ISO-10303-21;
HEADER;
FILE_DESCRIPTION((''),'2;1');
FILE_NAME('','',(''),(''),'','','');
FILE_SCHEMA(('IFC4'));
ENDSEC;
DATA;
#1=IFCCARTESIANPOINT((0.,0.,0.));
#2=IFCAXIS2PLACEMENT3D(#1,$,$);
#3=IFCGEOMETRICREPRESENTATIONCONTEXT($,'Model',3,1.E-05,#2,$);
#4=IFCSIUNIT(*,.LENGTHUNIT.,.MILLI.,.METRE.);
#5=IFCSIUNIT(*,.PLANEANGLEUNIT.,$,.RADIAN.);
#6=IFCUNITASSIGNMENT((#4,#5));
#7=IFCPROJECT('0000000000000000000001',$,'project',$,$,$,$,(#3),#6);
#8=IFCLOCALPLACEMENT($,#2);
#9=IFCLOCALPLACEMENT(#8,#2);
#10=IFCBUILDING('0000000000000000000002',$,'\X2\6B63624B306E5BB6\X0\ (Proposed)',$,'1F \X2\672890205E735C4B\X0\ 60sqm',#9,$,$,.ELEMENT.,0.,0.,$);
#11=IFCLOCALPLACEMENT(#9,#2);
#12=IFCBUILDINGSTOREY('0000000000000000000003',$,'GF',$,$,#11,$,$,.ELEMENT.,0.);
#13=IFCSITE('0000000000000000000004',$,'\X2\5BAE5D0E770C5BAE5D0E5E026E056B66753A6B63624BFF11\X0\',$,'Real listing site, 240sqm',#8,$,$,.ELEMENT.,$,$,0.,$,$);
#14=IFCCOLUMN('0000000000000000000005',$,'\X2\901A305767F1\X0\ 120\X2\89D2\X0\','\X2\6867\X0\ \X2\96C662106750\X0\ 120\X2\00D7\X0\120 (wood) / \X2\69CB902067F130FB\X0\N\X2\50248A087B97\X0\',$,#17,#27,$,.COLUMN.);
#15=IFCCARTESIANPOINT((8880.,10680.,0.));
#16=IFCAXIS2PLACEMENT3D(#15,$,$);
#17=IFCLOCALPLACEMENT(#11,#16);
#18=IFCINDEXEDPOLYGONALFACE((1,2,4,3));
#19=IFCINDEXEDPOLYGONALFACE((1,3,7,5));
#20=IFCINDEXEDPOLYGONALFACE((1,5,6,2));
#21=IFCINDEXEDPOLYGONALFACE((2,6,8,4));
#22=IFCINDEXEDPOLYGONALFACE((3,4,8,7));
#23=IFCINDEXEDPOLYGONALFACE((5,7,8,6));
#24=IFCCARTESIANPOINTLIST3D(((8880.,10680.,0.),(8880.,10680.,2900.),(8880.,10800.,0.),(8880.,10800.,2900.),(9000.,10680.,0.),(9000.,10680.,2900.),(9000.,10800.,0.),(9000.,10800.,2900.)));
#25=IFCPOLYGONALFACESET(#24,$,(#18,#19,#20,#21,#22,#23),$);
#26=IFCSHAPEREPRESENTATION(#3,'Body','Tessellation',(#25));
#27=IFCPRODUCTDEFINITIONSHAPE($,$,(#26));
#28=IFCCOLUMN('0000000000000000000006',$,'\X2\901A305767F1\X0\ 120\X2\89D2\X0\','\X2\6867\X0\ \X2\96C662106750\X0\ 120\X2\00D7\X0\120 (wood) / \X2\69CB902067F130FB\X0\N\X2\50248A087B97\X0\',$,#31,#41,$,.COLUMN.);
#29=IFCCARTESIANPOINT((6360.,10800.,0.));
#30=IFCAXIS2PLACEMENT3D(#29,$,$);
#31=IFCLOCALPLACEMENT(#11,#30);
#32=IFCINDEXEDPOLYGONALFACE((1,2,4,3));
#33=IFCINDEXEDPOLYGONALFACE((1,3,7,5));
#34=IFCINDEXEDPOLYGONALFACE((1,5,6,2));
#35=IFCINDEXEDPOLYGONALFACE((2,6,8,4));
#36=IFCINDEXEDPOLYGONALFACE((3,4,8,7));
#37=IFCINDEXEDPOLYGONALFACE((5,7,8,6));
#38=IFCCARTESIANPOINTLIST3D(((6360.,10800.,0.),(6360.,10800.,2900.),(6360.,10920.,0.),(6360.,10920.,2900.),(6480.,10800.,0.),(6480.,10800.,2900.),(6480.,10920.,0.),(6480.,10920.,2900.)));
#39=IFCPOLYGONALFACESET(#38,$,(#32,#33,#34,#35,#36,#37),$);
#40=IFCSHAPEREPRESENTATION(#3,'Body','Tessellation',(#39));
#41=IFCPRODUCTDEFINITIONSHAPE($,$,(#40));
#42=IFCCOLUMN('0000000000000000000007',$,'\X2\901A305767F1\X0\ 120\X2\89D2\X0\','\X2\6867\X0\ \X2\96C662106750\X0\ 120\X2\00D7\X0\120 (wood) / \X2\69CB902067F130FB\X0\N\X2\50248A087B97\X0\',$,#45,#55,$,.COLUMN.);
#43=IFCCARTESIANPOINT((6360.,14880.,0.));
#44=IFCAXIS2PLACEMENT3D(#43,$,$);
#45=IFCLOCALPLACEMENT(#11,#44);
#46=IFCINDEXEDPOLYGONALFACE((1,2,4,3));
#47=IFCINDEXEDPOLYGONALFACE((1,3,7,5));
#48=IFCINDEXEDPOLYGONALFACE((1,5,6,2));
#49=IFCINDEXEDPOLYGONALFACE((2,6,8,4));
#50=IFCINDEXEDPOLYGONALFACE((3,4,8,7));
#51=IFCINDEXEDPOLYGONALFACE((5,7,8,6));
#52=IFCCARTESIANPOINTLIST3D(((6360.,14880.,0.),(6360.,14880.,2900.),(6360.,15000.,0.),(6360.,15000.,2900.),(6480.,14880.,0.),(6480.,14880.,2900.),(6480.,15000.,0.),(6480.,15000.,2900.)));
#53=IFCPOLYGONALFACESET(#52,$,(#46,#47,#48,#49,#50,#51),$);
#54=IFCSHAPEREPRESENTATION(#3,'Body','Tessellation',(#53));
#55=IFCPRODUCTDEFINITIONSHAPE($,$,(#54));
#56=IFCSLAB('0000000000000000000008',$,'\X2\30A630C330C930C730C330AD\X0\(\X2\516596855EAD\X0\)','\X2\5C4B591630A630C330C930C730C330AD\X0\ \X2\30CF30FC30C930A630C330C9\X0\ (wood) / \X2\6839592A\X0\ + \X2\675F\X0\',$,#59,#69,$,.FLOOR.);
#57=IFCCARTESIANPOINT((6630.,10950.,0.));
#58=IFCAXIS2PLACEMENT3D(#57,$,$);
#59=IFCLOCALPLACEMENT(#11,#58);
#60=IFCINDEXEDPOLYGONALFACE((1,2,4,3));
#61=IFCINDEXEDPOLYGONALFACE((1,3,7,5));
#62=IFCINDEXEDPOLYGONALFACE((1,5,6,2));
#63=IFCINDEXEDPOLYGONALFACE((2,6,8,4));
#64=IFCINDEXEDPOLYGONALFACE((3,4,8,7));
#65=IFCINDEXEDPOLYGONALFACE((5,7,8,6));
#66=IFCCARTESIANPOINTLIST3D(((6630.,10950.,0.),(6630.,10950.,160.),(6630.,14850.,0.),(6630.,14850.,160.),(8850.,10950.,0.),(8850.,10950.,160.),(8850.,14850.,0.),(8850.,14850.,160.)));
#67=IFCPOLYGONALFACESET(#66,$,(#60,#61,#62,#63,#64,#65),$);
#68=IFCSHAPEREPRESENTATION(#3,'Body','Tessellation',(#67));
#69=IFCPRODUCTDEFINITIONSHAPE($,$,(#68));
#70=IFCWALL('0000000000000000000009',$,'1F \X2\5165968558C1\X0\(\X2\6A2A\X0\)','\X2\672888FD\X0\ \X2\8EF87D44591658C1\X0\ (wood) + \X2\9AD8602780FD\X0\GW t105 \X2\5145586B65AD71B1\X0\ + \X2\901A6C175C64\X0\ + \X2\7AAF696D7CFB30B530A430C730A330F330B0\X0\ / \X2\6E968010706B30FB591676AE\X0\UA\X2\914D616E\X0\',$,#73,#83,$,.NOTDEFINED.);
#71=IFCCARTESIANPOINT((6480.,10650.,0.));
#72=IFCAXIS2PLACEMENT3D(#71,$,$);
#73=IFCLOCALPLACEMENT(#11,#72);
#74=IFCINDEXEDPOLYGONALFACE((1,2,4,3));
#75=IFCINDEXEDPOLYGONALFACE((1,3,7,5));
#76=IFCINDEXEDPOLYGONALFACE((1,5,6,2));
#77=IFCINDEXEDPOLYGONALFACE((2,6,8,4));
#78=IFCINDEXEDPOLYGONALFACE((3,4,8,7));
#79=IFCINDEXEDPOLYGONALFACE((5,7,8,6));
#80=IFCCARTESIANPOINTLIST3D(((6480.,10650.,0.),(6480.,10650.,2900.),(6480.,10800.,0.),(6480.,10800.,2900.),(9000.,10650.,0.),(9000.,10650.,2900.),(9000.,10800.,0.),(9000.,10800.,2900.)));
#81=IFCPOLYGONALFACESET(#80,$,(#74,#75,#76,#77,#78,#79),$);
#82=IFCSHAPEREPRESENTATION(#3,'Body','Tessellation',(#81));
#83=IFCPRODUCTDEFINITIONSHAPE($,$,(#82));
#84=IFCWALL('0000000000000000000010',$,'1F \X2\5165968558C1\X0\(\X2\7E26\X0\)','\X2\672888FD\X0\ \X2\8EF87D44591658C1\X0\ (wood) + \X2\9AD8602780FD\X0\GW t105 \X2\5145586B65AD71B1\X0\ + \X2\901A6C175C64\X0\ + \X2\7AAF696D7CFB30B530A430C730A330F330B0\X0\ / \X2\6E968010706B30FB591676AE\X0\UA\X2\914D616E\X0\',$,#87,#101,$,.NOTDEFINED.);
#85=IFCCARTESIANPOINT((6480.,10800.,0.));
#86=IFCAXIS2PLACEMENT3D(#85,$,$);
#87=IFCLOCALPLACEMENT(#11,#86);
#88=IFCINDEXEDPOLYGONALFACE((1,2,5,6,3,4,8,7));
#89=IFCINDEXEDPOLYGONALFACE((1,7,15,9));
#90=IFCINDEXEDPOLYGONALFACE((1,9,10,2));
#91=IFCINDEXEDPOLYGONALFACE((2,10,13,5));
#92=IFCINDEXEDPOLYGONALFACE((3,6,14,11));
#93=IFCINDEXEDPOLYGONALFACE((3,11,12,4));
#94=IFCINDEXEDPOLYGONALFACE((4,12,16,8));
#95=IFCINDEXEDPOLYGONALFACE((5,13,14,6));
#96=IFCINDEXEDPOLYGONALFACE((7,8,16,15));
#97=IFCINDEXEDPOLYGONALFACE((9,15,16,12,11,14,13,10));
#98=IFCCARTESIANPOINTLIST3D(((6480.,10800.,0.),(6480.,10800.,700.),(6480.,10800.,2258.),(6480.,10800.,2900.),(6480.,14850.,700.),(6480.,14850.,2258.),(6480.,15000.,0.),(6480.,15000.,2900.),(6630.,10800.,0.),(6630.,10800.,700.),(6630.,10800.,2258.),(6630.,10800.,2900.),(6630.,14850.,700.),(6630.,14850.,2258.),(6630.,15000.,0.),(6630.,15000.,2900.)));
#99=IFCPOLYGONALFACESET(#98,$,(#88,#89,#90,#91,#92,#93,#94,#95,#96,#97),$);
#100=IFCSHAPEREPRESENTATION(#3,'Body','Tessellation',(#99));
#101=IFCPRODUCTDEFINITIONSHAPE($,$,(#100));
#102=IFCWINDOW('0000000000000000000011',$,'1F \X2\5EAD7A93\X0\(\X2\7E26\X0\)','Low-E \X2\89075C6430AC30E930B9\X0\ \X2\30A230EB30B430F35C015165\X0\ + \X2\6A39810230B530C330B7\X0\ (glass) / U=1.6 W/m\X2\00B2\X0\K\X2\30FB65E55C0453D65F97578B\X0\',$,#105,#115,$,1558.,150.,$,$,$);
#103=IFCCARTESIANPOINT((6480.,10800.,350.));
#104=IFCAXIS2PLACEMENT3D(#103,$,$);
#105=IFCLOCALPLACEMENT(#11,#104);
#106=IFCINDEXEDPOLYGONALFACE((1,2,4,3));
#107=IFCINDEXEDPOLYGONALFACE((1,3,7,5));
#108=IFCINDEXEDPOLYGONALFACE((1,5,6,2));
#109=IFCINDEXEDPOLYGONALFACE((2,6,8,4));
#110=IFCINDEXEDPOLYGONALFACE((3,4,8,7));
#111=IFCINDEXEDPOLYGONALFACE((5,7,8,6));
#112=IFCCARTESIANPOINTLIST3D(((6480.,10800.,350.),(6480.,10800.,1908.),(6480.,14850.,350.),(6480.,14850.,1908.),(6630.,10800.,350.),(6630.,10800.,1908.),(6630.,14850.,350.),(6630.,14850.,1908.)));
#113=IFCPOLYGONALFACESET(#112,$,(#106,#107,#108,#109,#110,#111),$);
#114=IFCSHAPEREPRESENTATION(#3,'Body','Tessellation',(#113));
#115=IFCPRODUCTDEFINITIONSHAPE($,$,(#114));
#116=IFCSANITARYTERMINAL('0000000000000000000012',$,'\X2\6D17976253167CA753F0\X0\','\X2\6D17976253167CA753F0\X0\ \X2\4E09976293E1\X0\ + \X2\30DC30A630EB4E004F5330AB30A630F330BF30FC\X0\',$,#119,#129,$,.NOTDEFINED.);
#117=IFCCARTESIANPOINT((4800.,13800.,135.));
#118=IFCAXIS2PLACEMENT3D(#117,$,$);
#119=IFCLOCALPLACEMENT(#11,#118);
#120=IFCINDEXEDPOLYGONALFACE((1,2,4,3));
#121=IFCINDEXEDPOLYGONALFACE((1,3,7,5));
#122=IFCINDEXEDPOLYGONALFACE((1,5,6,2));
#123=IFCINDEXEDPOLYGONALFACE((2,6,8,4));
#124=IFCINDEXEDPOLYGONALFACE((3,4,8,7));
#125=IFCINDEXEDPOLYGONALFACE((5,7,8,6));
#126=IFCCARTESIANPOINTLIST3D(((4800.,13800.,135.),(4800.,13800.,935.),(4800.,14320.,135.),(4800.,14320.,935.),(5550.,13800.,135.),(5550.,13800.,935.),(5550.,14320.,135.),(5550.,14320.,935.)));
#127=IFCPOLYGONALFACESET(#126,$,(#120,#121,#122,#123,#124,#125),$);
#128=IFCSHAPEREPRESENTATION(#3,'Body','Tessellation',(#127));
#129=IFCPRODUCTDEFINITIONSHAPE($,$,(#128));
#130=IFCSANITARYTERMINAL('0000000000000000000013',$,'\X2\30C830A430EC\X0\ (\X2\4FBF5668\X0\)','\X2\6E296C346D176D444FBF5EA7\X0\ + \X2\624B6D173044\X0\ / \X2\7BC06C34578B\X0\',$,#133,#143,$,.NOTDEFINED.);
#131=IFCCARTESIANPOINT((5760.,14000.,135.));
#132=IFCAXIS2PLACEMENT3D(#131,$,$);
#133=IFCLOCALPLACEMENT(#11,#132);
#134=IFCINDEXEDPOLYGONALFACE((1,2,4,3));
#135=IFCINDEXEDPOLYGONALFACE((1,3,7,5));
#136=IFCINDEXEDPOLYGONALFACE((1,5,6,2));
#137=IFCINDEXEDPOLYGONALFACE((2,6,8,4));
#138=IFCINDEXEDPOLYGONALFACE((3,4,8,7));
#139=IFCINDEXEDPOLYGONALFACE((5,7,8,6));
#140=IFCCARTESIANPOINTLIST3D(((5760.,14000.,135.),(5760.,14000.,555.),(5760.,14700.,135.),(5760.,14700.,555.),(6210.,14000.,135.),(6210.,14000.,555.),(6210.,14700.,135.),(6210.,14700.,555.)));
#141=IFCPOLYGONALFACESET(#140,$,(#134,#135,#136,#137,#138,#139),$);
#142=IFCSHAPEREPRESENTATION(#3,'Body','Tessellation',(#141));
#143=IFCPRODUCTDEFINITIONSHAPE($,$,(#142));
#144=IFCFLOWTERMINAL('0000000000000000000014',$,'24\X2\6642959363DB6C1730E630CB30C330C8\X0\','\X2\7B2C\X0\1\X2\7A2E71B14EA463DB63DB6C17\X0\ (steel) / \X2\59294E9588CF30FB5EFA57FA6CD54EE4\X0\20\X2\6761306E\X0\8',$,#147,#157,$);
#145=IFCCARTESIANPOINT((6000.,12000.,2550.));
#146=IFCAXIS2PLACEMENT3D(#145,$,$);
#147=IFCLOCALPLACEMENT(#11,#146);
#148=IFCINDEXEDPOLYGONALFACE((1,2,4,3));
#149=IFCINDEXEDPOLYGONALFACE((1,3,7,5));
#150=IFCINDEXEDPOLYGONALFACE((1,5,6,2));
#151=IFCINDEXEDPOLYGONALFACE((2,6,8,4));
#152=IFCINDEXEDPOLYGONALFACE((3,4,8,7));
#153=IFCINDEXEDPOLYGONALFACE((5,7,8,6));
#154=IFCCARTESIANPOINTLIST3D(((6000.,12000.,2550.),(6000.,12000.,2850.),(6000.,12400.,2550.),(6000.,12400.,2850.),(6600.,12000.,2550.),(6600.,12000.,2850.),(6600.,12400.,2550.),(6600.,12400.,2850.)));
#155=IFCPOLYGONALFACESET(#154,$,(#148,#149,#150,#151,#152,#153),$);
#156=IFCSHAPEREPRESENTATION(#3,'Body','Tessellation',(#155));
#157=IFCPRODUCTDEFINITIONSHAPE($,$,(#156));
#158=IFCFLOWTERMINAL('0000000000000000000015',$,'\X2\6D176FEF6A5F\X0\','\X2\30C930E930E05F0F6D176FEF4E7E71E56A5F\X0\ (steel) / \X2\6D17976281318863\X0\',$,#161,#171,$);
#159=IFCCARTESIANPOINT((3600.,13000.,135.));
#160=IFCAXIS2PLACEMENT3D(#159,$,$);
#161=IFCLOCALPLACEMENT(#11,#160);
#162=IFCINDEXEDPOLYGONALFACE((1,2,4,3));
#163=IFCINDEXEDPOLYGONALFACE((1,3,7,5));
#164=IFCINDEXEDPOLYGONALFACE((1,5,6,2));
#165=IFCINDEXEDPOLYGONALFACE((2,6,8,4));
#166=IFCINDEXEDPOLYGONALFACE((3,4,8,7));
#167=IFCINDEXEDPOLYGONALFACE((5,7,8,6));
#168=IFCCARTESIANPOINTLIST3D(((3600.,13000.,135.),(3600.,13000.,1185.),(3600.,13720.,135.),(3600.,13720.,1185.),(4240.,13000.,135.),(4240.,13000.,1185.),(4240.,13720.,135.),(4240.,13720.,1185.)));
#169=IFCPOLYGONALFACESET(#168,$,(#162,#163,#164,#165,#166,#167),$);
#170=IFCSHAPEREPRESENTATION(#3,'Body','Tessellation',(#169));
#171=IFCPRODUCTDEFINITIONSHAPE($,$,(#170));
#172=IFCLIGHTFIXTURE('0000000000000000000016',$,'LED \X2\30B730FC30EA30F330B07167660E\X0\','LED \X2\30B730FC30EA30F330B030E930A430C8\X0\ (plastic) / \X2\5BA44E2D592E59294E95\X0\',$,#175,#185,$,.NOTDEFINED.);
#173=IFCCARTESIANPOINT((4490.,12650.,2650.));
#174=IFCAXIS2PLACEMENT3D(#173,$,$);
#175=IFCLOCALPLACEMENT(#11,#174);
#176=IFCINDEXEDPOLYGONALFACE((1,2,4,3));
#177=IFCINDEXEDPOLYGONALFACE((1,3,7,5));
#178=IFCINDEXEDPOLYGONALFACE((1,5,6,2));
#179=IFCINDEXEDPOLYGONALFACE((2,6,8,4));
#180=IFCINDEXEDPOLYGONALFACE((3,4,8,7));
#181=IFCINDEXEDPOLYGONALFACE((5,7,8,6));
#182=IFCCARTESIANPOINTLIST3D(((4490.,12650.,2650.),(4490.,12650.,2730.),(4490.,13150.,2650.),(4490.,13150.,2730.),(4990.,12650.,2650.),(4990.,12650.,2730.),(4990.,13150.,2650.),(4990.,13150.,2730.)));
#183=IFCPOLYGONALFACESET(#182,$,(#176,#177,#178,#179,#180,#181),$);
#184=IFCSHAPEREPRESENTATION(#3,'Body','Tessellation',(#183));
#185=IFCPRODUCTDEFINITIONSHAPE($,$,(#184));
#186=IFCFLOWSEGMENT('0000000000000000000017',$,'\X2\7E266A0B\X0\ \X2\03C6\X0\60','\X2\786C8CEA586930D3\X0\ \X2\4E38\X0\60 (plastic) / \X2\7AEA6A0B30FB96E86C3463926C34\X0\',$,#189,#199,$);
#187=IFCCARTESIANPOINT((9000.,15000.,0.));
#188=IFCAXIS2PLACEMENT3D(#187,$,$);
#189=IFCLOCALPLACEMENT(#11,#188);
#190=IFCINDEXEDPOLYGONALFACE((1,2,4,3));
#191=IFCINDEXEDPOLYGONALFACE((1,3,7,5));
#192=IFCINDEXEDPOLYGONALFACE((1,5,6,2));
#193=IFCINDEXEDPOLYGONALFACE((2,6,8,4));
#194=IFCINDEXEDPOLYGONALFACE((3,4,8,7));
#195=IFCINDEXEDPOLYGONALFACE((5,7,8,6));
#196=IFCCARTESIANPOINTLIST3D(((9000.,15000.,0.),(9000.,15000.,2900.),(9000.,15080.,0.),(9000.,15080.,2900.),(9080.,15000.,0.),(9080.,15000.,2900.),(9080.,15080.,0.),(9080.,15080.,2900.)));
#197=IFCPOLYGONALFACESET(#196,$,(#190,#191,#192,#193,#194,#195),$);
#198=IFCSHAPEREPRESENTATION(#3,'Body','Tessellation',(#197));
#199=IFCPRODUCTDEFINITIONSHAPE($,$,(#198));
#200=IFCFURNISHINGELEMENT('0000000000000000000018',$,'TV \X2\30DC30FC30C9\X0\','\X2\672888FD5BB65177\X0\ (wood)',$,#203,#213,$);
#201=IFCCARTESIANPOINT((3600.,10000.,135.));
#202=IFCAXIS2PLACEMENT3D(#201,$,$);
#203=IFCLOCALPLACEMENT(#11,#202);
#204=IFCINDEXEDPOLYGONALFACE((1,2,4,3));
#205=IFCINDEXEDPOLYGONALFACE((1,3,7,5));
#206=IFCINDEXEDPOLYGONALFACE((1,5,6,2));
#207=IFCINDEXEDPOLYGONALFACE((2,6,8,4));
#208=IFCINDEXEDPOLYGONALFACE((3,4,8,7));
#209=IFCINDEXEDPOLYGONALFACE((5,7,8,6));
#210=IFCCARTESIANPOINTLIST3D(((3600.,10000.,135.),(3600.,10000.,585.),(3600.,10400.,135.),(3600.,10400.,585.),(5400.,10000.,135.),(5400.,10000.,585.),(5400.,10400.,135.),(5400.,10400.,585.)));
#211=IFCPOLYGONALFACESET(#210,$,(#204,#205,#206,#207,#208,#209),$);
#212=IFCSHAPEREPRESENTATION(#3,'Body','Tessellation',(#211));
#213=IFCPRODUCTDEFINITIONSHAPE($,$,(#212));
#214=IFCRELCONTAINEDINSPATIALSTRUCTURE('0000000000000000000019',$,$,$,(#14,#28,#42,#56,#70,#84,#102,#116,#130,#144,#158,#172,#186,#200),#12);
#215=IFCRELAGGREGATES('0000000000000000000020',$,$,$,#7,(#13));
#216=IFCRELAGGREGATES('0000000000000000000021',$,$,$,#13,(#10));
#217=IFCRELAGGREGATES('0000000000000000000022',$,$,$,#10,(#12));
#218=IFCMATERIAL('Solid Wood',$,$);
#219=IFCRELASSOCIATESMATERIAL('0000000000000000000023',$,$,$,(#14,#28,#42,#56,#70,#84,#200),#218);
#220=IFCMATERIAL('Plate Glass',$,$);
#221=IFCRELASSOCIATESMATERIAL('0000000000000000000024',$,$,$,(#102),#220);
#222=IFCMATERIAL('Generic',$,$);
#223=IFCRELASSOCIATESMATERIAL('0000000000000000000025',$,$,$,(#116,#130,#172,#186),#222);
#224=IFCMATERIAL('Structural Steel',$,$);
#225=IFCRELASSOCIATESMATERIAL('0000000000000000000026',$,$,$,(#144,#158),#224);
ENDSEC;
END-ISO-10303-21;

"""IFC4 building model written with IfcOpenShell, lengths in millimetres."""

from ifc_helpers import new_model, si_unit, frame, frame_2d, origin, place, context, project, spatial, rectangle, extrude, material, element, fill, save


model = new_model("IFC4")

# Units and contexts
model_context = context("Model", 3, precision=1e-05, world=origin())
ifc_project = project(units=[si_unit("LENGTHUNIT", "METRE", prefix="MILLI"), si_unit("PLANEANGLEUNIT", "RADIAN")], contexts=[model_context])

# Site, building, storey
site_placement = place(None, origin())
site = spatial("IfcSite", under=ifc_project, at=site_placement, Name="宮崎県宮崎市清武町正手１", ObjectType="Real listing site, 240sqm", CompositionType="ELEMENT", RefElevation=0.0)
building_placement = place(site_placement, origin())
building = spatial("IfcBuilding", under=site, at=building_placement, Name="正手の家 (Proposed)", ObjectType="1F 木造平屋 60sqm", CompositionType="ELEMENT", ElevationOfRefHeight=0.0, ElevationOfTerrain=0.0)
storey_placement = place(building_placement, origin())
storey = spatial("IfcBuildingStorey", under=building, at=storey_placement, Name="GF", CompositionType="ELEMENT", Elevation=0.0)

# Columns
ifc_material_1 = material(Name="Solid Wood")
column_1_placement = place(storey_placement, frame((8880.0, 10680.0, 0.0)))
element("IfcColumn", 1, at=column_1_placement, inside=storey, material=ifc_material_1, Name="通し柱 120角", Description="桧 集成材 120×120 (wood) / 構造柱・N値計算", PredefinedType="COLUMN", context=model_context, shape_type="SweptSolid", body=[
    extrude(rectangle(XDim=120.0, YDim=120.0, at=frame_2d((60.0, 60.0))), frame((8880.0, 10680.0, 0.0)), (0.0, 0.0, 1.0), 2900.0),
])
column_2_placement = place(storey_placement, frame((6360.0, 10800.0, 0.0)))
element("IfcColumn", 2, at=column_2_placement, inside=storey, material=ifc_material_1, Name="通し柱 120角", Description="桧 集成材 120×120 (wood) / 構造柱・N値計算", PredefinedType="COLUMN", context=model_context, shape_type="SweptSolid", body=[
    extrude(rectangle(XDim=120.0, YDim=120.0, at=frame_2d((60.0, 60.0))), frame((6360.0, 10800.0, 0.0)), (0.0, 0.0, 1.0), 2900.0),
])
column_3_placement = place(storey_placement, frame((6360.0, 14880.0, 0.0)))
element("IfcColumn", 3, at=column_3_placement, inside=storey, material=ifc_material_1, Name="通し柱 120角", Description="桧 集成材 120×120 (wood) / 構造柱・N値計算", PredefinedType="COLUMN", context=model_context, shape_type="SweptSolid", body=[
    extrude(rectangle(XDim=120.0, YDim=120.0, at=frame_2d((60.0, 60.0))), frame((6360.0, 14880.0, 0.0)), (0.0, 0.0, 1.0), 2900.0),
])

# Slab
slab_placement = place(storey_placement, frame((6630.0, 10950.0, 0.0)))
element("IfcSlab", 4, at=slab_placement, inside=storey, material=ifc_material_1, Name="ウッドデッキ(入隅庭)", Description="屋外ウッドデッキ ハードウッド (wood) / 根太 + 束", PredefinedType="FLOOR", context=model_context, shape_type="SweptSolid", body=[
    extrude(rectangle(XDim=2220.0, YDim=3900.0, at=frame_2d((1110.0, 1950.0))), frame((6630.0, 10950.0, 0.0)), (0.0, 0.0, 1.0), 160.0),
])

# Wall
wall_1_placement = place(storey_placement, frame((6480.0, 10650.0, 0.0)))
element("IfcWall", 5, at=wall_1_placement, inside=storey, material=ifc_material_1, Name="1F 入隅壁(横)", Description="木製 軸組外壁 (wood) + 高性能GW t105 充填断熱 + 通気層 + 窯業系サイディング / 準耐火・外皮UA配慮", PredefinedType="NOTDEFINED", context=model_context, shape_type="SweptSolid", body=[
    extrude(rectangle(XDim=2520.0, YDim=150.0, at=frame_2d((1260.0, 75.0))), frame((6480.0, 10650.0, 0.0)), (0.0, 0.0, 1.0), 2900.0),
])

# Wall, opening, window
wall_2_placement = place(storey_placement, frame((6480.0, 10800.0, 0.0)))
wall_2 = element("IfcWall", 6, at=wall_2_placement, inside=storey, material=ifc_material_1, Name="1F 入隅壁(縦)", Description="木製 軸組外壁 (wood) + 高性能GW t105 充填断熱 + 通気層 + 窯業系サイディング / 準耐火・外皮UA配慮", PredefinedType="NOTDEFINED", context=model_context, shape_type="SweptSolid", body=[
    extrude(rectangle(XDim=150.0, YDim=4200.0, at=frame_2d((75.0, 2100.0))), frame((6480.0, 10800.0, 0.0)), (0.0, 0.0, 1.0), 2900.0),
])
opening_placement = place(storey_placement, frame((6480.0, 10800.0, 350.0)))
opening = element("IfcOpeningElement", 7, at=opening_placement, cuts=wall_2, PredefinedType="NOTDEFINED", context=model_context, shape_type="SweptSolid", body=[
    extrude(rectangle(XDim=150.0, YDim=4050.0, at=frame_2d((75.0, 2025.0))), frame((6480.0, 10800.0, 350.0)), (0.0, 0.0, 1.0), 1558.0),
])
ifc_material_2 = material(Name="Plate Glass")
window_placement = place(storey_placement, frame((6480.0, 10800.0, 350.0)))
window = element("IfcWindow", 8, at=window_placement, inside=storey, material=ifc_material_2, Name="1F 庭窓(縦)", Description="Low-E 複層ガラス アルゴン封入 + 樹脂サッシ (glass) / U=1.6 W/m²K・日射取得型", OverallHeight=1558.0, OverallWidth=150.0, context=model_context, shape_type="SweptSolid", body=[
    extrude(rectangle(XDim=150.0, YDim=4050.0, at=frame_2d((75.0, 2025.0))), frame((6480.0, 10800.0, 350.0)), (0.0, 0.0, 1.0), 1558.0),
])
fill(opening, window)

# Sanitary terminals
ifc_material_3 = material(Name="Generic")
sanitary_terminal_1_placement = place(storey_placement, frame((4800.0, 13800.0, 135.0)))
element("IfcSanitaryTerminal", 9, at=sanitary_terminal_1_placement, inside=storey, material=ifc_material_3, Name="洗面化粧台", Description="洗面化粧台 三面鏡 + ボウル一体カウンター", PredefinedType="NOTDEFINED", context=model_context, shape_type="SweptSolid", body=[
    extrude(rectangle(XDim=750.0, YDim=520.0, at=frame_2d((375.0, 260.0))), frame((4800.0, 13800.0, 135.0)), (0.0, 0.0, 1.0), 800.0),
])
sanitary_terminal_2_placement = place(storey_placement, frame((5760.0, 14000.0, 135.0)))
element("IfcSanitaryTerminal", 10, at=sanitary_terminal_2_placement, inside=storey, material=ifc_material_3, Name="トイレ (便器)", Description="温水洗浄便座 + 手洗い / 節水型", PredefinedType="NOTDEFINED", context=model_context, shape_type="SweptSolid", body=[
    extrude(rectangle(XDim=450.0, YDim=700.0, at=frame_2d((225.0, 350.0))), frame((5760.0, 14000.0, 135.0)), (0.0, 0.0, 1.0), 420.0),
])

# Flow terminals
ifc_material_4 = material(Name="Structural Steel")
flow_terminal_1_placement = place(storey_placement, frame((6000.0, 12000.0, 2550.0)))
element("IfcFlowTerminal", 11, at=flow_terminal_1_placement, inside=storey, material=ifc_material_4, Name="24時間換気ユニット", Description="第1種熱交換換気 (steel) / 天井裏・建基法令20条の8", context=model_context, shape_type="SweptSolid", body=[
    extrude(rectangle(XDim=600.0, YDim=400.0, at=frame_2d((300.0, 200.0))), frame((6000.0, 12000.0, 2550.0)), (0.0, 0.0, 1.0), 300.0),
])
flow_terminal_2_placement = place(storey_placement, frame((3600.0, 13000.0, 135.0)))
element("IfcFlowTerminal", 12, at=flow_terminal_2_placement, inside=storey, material=ifc_material_4, Name="洗濯機", Description="ドラム式洗濯乾燥機 (steel) / 洗面脱衣", context=model_context, shape_type="SweptSolid", body=[
    extrude(rectangle(XDim=640.0, YDim=720.0, at=frame_2d((320.0, 360.0))), frame((3600.0, 13000.0, 135.0)), (0.0, 0.0, 1.0), 1050.0),
])

# Light fixture
light_fixture_placement = place(storey_placement, frame((4490.0, 12650.0, 2650.0)))
element("IfcLightFixture", 13, at=light_fixture_placement, inside=storey, material=ifc_material_3, Name="LED シーリング照明", Description="LED シーリングライト (plastic) / 室中央天井", PredefinedType="NOTDEFINED", context=model_context, shape_type="SweptSolid", body=[
    extrude(rectangle(XDim=500.0, YDim=500.0, at=frame_2d((250.0, 250.0))), frame((4490.0, 12650.0, 2650.0)), (0.0, 0.0, 1.0), 80.0),
])

# Flow segment
flow_segment_placement = place(storey_placement, frame((9000.0, 15000.0, 0.0)))
element("IfcFlowSegment", 14, at=flow_segment_placement, inside=storey, material=ifc_material_3, Name="縦樋 φ60", Description="硬質塩ビ 丸60 (plastic) / 竪樋・雨水排水", context=model_context, shape_type="SweptSolid", body=[
    extrude(rectangle(XDim=80.0, YDim=80.0, at=frame_2d((40.0, 40.0))), frame((9000.0, 15000.0, 0.0)), (0.0, 0.0, 1.0), 2900.0),
])

# Furnishing element
furnishing_placement = place(storey_placement, frame((3600.0, 10000.0, 135.0)))
element("IfcFurnishingElement", 15, at=furnishing_placement, inside=storey, material=ifc_material_1, Name="TV ボード", Description="木製家具 (wood)", context=model_context, shape_type="SweptSolid", body=[
    extrude(rectangle(XDim=1800.0, YDim=400.0, at=frame_2d((900.0, 200.0))), frame((3600.0, 10000.0, 135.0)), (0.0, 0.0, 1.0), 450.0),
])

save(model, "model.ifc")
